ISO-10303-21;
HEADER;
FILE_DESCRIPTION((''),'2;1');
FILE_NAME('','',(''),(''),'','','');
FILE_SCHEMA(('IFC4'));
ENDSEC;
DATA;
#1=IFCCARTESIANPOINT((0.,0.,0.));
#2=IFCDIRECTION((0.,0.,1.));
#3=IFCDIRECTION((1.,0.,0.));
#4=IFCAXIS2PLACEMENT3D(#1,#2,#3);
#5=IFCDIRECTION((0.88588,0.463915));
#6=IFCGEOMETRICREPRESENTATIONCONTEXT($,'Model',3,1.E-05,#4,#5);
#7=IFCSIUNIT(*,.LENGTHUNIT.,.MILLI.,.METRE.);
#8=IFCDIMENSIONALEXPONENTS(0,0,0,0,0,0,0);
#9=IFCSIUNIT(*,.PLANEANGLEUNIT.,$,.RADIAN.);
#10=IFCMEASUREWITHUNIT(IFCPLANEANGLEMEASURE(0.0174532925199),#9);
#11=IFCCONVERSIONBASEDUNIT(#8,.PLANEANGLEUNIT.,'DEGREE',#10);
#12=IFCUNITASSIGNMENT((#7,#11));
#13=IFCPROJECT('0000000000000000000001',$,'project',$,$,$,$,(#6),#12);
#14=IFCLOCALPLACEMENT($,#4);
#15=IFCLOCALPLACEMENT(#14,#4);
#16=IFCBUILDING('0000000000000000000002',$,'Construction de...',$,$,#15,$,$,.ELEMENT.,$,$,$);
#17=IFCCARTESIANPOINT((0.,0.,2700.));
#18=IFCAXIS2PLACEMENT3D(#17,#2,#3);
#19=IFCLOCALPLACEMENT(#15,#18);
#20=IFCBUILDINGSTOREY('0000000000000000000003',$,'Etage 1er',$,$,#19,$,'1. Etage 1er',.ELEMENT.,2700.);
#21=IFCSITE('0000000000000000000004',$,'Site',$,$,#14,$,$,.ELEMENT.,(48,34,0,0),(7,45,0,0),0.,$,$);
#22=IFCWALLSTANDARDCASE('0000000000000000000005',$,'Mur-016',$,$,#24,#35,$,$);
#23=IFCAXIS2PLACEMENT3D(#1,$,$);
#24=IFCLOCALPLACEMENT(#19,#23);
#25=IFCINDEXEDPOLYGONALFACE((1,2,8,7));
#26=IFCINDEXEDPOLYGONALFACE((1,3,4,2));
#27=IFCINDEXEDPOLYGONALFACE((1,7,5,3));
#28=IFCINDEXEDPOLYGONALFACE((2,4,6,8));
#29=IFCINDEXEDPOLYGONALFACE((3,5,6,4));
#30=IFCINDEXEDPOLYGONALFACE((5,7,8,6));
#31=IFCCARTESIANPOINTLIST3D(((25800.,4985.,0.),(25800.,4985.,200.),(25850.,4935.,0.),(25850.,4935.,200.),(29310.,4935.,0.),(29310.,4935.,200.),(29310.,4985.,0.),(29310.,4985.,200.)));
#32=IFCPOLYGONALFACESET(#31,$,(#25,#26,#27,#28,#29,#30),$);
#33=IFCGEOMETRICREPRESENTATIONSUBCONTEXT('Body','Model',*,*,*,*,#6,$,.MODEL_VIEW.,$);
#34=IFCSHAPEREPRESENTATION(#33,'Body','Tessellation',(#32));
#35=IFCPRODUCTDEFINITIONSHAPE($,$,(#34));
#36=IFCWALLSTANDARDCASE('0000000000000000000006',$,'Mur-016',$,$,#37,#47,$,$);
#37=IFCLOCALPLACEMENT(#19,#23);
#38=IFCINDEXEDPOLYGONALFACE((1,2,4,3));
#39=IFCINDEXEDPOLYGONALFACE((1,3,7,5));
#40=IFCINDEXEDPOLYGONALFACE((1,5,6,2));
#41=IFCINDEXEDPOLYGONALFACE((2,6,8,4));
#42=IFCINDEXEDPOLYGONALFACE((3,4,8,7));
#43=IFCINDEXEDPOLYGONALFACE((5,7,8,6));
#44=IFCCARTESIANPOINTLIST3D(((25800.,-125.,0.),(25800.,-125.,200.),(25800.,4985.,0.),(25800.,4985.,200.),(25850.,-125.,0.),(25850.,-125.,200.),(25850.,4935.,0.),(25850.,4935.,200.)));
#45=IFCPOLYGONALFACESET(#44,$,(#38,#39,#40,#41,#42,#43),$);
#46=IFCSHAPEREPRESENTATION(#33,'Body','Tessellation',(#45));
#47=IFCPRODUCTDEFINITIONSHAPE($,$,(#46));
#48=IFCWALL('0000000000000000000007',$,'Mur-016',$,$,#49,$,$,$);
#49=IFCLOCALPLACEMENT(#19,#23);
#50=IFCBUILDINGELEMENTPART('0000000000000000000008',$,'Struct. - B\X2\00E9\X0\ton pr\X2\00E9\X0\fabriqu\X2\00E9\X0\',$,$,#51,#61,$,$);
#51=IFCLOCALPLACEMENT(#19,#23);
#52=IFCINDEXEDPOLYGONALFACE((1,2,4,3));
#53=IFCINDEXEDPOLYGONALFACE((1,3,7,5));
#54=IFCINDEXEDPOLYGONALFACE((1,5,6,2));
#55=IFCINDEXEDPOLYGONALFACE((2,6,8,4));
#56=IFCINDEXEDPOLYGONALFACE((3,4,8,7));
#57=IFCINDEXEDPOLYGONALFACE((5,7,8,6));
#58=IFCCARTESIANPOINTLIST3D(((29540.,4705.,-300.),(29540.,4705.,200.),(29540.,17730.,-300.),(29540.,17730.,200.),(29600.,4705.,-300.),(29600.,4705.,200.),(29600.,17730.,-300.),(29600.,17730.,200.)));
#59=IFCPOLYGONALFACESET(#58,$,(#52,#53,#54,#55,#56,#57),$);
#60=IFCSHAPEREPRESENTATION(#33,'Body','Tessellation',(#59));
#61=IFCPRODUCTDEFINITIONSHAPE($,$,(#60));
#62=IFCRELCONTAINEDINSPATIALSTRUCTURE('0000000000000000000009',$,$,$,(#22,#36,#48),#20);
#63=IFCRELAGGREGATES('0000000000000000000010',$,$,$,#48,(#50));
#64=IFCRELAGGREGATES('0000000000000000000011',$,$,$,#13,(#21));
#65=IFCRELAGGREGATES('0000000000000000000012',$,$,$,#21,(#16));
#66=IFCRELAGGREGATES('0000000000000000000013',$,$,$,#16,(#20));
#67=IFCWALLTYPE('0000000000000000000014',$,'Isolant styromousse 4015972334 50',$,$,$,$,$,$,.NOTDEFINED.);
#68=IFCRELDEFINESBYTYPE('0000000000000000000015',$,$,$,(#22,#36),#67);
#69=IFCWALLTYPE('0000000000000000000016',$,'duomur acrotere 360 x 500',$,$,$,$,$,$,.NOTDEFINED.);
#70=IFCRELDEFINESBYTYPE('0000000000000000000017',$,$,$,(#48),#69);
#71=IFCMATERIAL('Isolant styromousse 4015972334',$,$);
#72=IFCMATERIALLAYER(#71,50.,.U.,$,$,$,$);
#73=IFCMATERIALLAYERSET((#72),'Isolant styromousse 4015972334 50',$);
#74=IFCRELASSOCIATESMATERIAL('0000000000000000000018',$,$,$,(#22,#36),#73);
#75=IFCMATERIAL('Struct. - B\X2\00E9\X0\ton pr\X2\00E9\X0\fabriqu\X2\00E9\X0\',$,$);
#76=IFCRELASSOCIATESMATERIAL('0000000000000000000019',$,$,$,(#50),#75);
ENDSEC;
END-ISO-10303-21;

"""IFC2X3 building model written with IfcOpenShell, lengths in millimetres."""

from ifc_helpers import new_model, entity, si_unit, converted_unit, direction, frame, origin_with_axes, place, context, subcontext, project, spatial, polyline, outline, extrude, material, layer, layer_set, layer_usage, type_object, element, aggregate, save


model = new_model("IFC2X3")

# Units and contexts
model_context = context("Model", 3, precision=1e-05, world=origin_with_axes(), true_north=direction((0.88588, 0.463915)))
body_context = subcontext(model_context, "Body", "Model", "MODEL_VIEW")
ifc_project = project(units=[si_unit("LENGTHUNIT", "METRE", prefix="MILLI"), converted_unit("PLANEANGLEUNIT", "DEGREE", entity("IfcPlaneAngleMeasure", 0.0174532925199), si_unit("PLANEANGLEUNIT", "RADIAN"), dimensions=[0, 0, 0, 0, 0, 0, 0])], contexts=[model_context])

# Site, building, storey
site_placement = place(None, origin_with_axes())
site = spatial("IfcSite", under=ifc_project, at=site_placement, Name="Site", CompositionType="ELEMENT", RefLatitude=(48, 34, 0, 0), RefLongitude=(7, 45, 0, 0), RefElevation=0.0)
building_placement = place(site_placement, origin_with_axes())
building = spatial("IfcBuilding", under=site, at=building_placement, Name="Construction de...", CompositionType="ELEMENT")
storey_placement = place(building_placement, frame((0.0, 0.0, 2700.0), z_axis=(0.0, 0.0, 1.0), x_axis=(1.0, 0.0, 0.0)))
storey = spatial("IfcBuildingStorey", under=building, at=storey_placement, Name="Etage 1er", LongName="1. Etage 1er", CompositionType="ELEMENT", Elevation=2700.0)

# Walls
ifc_material_1 = material(Name="Isolant styromousse 4015972334")
ifc_layer_1 = layer(ifc_material_1, 50.0, ventilated="UNKNOWN")
ifc_layer_set_1 = layer_set([ifc_layer_1], Name="Isolant styromousse 4015972334 50")
ifc_layer_usage_1 = layer_usage(ifc_layer_set_1, "AXIS2", "NEGATIVE", 25.0)
wall_type_1 = type_object("IfcWallType", Name="Isolant styromousse 4015972334 50", PredefinedType="NOTDEFINED")
wall_1_placement = place(storey_placement, frame((25825.0, 4960.0, 0.0), z_axis=(0.0, 0.0, 1.0), x_axis=(1.0, 0.0, 0.0)))
element("IfcWallStandardCase", 1, at=wall_1_placement, inside=storey, type_object=wall_type_1, material=ifc_layer_usage_1, Name="Mur-016", context=body_context, shape_type="SweptSolid", body=[
    extrude(outline(polyline([(25.0, -25.0), (3485.0, -25.0), (3485.0, 25.0), (-25.0, 25.0), (25.0, -25.0)])), origin_with_axes(), (0.0, 0.0, 1.0), 200.0),
])
ifc_layer_usage_2 = layer_usage(ifc_layer_set_1, "AXIS2", "POSITIVE", -25.0)
wall_2_placement = place(storey_placement, frame((25825.0, 4960.0, 0.0), z_axis=(0.0, 0.0, 1.0), x_axis=(0.0, -1.0, 0.0)))
element("IfcWallStandardCase", 2, at=wall_2_placement, inside=storey, type_object=wall_type_1, material=ifc_layer_usage_2, Name="Mur-016", context=body_context, shape_type="SweptSolid", body=[
    extrude(outline(polyline([(-25.0, -25.0), (5085.0, -25.0), (5085.0, 25.0), (25.0, 25.0), (-25.0, -25.0)])), origin_with_axes(), (0.0, 0.0, 1.0), 200.0),
])

# Wall, building element part
wall_type_2 = type_object("IfcWallType", Name="duomur acrotere 360 x 500", PredefinedType="NOTDEFINED")
wall_3_placement = place(storey_placement, frame((29500.0, 4705.0, -300.0), z_axis=(0.0, 0.0, 1.0), x_axis=(0.0, 1.0, 0.0)))
wall_3 = element("IfcWall", 3, at=wall_3_placement, inside=storey, type_object=wall_type_2, Name="Mur-016")
ifc_material_2 = material(Name="Struct. - Béton préfabriqué")
building_element_part_1_placement = place(wall_3_placement, origin_with_axes())
building_element_part_1 = element("IfcBuildingElementPart", 4, at=building_element_part_1_placement, material=ifc_material_2, Name="Struct. - Béton préfabriqué", context=body_context, shape_type="SweptSolid", body=[
    extrude(outline(polyline([(-60.0, 0.0), (0.0, 0.0), (0.0, 500.0), (-60.0, 500.0), (-60.0, 0.0)])), frame((0.0, -100.0, 0.0), z_axis=(-1.0, 0.0, 0.0), x_axis=(0.0, -1.0, 0.0)), (0.0, 0.0, -1.0), 13025.0),
])
aggregate(wall_3, [building_element_part_1])

save(model, "model.ifc")
